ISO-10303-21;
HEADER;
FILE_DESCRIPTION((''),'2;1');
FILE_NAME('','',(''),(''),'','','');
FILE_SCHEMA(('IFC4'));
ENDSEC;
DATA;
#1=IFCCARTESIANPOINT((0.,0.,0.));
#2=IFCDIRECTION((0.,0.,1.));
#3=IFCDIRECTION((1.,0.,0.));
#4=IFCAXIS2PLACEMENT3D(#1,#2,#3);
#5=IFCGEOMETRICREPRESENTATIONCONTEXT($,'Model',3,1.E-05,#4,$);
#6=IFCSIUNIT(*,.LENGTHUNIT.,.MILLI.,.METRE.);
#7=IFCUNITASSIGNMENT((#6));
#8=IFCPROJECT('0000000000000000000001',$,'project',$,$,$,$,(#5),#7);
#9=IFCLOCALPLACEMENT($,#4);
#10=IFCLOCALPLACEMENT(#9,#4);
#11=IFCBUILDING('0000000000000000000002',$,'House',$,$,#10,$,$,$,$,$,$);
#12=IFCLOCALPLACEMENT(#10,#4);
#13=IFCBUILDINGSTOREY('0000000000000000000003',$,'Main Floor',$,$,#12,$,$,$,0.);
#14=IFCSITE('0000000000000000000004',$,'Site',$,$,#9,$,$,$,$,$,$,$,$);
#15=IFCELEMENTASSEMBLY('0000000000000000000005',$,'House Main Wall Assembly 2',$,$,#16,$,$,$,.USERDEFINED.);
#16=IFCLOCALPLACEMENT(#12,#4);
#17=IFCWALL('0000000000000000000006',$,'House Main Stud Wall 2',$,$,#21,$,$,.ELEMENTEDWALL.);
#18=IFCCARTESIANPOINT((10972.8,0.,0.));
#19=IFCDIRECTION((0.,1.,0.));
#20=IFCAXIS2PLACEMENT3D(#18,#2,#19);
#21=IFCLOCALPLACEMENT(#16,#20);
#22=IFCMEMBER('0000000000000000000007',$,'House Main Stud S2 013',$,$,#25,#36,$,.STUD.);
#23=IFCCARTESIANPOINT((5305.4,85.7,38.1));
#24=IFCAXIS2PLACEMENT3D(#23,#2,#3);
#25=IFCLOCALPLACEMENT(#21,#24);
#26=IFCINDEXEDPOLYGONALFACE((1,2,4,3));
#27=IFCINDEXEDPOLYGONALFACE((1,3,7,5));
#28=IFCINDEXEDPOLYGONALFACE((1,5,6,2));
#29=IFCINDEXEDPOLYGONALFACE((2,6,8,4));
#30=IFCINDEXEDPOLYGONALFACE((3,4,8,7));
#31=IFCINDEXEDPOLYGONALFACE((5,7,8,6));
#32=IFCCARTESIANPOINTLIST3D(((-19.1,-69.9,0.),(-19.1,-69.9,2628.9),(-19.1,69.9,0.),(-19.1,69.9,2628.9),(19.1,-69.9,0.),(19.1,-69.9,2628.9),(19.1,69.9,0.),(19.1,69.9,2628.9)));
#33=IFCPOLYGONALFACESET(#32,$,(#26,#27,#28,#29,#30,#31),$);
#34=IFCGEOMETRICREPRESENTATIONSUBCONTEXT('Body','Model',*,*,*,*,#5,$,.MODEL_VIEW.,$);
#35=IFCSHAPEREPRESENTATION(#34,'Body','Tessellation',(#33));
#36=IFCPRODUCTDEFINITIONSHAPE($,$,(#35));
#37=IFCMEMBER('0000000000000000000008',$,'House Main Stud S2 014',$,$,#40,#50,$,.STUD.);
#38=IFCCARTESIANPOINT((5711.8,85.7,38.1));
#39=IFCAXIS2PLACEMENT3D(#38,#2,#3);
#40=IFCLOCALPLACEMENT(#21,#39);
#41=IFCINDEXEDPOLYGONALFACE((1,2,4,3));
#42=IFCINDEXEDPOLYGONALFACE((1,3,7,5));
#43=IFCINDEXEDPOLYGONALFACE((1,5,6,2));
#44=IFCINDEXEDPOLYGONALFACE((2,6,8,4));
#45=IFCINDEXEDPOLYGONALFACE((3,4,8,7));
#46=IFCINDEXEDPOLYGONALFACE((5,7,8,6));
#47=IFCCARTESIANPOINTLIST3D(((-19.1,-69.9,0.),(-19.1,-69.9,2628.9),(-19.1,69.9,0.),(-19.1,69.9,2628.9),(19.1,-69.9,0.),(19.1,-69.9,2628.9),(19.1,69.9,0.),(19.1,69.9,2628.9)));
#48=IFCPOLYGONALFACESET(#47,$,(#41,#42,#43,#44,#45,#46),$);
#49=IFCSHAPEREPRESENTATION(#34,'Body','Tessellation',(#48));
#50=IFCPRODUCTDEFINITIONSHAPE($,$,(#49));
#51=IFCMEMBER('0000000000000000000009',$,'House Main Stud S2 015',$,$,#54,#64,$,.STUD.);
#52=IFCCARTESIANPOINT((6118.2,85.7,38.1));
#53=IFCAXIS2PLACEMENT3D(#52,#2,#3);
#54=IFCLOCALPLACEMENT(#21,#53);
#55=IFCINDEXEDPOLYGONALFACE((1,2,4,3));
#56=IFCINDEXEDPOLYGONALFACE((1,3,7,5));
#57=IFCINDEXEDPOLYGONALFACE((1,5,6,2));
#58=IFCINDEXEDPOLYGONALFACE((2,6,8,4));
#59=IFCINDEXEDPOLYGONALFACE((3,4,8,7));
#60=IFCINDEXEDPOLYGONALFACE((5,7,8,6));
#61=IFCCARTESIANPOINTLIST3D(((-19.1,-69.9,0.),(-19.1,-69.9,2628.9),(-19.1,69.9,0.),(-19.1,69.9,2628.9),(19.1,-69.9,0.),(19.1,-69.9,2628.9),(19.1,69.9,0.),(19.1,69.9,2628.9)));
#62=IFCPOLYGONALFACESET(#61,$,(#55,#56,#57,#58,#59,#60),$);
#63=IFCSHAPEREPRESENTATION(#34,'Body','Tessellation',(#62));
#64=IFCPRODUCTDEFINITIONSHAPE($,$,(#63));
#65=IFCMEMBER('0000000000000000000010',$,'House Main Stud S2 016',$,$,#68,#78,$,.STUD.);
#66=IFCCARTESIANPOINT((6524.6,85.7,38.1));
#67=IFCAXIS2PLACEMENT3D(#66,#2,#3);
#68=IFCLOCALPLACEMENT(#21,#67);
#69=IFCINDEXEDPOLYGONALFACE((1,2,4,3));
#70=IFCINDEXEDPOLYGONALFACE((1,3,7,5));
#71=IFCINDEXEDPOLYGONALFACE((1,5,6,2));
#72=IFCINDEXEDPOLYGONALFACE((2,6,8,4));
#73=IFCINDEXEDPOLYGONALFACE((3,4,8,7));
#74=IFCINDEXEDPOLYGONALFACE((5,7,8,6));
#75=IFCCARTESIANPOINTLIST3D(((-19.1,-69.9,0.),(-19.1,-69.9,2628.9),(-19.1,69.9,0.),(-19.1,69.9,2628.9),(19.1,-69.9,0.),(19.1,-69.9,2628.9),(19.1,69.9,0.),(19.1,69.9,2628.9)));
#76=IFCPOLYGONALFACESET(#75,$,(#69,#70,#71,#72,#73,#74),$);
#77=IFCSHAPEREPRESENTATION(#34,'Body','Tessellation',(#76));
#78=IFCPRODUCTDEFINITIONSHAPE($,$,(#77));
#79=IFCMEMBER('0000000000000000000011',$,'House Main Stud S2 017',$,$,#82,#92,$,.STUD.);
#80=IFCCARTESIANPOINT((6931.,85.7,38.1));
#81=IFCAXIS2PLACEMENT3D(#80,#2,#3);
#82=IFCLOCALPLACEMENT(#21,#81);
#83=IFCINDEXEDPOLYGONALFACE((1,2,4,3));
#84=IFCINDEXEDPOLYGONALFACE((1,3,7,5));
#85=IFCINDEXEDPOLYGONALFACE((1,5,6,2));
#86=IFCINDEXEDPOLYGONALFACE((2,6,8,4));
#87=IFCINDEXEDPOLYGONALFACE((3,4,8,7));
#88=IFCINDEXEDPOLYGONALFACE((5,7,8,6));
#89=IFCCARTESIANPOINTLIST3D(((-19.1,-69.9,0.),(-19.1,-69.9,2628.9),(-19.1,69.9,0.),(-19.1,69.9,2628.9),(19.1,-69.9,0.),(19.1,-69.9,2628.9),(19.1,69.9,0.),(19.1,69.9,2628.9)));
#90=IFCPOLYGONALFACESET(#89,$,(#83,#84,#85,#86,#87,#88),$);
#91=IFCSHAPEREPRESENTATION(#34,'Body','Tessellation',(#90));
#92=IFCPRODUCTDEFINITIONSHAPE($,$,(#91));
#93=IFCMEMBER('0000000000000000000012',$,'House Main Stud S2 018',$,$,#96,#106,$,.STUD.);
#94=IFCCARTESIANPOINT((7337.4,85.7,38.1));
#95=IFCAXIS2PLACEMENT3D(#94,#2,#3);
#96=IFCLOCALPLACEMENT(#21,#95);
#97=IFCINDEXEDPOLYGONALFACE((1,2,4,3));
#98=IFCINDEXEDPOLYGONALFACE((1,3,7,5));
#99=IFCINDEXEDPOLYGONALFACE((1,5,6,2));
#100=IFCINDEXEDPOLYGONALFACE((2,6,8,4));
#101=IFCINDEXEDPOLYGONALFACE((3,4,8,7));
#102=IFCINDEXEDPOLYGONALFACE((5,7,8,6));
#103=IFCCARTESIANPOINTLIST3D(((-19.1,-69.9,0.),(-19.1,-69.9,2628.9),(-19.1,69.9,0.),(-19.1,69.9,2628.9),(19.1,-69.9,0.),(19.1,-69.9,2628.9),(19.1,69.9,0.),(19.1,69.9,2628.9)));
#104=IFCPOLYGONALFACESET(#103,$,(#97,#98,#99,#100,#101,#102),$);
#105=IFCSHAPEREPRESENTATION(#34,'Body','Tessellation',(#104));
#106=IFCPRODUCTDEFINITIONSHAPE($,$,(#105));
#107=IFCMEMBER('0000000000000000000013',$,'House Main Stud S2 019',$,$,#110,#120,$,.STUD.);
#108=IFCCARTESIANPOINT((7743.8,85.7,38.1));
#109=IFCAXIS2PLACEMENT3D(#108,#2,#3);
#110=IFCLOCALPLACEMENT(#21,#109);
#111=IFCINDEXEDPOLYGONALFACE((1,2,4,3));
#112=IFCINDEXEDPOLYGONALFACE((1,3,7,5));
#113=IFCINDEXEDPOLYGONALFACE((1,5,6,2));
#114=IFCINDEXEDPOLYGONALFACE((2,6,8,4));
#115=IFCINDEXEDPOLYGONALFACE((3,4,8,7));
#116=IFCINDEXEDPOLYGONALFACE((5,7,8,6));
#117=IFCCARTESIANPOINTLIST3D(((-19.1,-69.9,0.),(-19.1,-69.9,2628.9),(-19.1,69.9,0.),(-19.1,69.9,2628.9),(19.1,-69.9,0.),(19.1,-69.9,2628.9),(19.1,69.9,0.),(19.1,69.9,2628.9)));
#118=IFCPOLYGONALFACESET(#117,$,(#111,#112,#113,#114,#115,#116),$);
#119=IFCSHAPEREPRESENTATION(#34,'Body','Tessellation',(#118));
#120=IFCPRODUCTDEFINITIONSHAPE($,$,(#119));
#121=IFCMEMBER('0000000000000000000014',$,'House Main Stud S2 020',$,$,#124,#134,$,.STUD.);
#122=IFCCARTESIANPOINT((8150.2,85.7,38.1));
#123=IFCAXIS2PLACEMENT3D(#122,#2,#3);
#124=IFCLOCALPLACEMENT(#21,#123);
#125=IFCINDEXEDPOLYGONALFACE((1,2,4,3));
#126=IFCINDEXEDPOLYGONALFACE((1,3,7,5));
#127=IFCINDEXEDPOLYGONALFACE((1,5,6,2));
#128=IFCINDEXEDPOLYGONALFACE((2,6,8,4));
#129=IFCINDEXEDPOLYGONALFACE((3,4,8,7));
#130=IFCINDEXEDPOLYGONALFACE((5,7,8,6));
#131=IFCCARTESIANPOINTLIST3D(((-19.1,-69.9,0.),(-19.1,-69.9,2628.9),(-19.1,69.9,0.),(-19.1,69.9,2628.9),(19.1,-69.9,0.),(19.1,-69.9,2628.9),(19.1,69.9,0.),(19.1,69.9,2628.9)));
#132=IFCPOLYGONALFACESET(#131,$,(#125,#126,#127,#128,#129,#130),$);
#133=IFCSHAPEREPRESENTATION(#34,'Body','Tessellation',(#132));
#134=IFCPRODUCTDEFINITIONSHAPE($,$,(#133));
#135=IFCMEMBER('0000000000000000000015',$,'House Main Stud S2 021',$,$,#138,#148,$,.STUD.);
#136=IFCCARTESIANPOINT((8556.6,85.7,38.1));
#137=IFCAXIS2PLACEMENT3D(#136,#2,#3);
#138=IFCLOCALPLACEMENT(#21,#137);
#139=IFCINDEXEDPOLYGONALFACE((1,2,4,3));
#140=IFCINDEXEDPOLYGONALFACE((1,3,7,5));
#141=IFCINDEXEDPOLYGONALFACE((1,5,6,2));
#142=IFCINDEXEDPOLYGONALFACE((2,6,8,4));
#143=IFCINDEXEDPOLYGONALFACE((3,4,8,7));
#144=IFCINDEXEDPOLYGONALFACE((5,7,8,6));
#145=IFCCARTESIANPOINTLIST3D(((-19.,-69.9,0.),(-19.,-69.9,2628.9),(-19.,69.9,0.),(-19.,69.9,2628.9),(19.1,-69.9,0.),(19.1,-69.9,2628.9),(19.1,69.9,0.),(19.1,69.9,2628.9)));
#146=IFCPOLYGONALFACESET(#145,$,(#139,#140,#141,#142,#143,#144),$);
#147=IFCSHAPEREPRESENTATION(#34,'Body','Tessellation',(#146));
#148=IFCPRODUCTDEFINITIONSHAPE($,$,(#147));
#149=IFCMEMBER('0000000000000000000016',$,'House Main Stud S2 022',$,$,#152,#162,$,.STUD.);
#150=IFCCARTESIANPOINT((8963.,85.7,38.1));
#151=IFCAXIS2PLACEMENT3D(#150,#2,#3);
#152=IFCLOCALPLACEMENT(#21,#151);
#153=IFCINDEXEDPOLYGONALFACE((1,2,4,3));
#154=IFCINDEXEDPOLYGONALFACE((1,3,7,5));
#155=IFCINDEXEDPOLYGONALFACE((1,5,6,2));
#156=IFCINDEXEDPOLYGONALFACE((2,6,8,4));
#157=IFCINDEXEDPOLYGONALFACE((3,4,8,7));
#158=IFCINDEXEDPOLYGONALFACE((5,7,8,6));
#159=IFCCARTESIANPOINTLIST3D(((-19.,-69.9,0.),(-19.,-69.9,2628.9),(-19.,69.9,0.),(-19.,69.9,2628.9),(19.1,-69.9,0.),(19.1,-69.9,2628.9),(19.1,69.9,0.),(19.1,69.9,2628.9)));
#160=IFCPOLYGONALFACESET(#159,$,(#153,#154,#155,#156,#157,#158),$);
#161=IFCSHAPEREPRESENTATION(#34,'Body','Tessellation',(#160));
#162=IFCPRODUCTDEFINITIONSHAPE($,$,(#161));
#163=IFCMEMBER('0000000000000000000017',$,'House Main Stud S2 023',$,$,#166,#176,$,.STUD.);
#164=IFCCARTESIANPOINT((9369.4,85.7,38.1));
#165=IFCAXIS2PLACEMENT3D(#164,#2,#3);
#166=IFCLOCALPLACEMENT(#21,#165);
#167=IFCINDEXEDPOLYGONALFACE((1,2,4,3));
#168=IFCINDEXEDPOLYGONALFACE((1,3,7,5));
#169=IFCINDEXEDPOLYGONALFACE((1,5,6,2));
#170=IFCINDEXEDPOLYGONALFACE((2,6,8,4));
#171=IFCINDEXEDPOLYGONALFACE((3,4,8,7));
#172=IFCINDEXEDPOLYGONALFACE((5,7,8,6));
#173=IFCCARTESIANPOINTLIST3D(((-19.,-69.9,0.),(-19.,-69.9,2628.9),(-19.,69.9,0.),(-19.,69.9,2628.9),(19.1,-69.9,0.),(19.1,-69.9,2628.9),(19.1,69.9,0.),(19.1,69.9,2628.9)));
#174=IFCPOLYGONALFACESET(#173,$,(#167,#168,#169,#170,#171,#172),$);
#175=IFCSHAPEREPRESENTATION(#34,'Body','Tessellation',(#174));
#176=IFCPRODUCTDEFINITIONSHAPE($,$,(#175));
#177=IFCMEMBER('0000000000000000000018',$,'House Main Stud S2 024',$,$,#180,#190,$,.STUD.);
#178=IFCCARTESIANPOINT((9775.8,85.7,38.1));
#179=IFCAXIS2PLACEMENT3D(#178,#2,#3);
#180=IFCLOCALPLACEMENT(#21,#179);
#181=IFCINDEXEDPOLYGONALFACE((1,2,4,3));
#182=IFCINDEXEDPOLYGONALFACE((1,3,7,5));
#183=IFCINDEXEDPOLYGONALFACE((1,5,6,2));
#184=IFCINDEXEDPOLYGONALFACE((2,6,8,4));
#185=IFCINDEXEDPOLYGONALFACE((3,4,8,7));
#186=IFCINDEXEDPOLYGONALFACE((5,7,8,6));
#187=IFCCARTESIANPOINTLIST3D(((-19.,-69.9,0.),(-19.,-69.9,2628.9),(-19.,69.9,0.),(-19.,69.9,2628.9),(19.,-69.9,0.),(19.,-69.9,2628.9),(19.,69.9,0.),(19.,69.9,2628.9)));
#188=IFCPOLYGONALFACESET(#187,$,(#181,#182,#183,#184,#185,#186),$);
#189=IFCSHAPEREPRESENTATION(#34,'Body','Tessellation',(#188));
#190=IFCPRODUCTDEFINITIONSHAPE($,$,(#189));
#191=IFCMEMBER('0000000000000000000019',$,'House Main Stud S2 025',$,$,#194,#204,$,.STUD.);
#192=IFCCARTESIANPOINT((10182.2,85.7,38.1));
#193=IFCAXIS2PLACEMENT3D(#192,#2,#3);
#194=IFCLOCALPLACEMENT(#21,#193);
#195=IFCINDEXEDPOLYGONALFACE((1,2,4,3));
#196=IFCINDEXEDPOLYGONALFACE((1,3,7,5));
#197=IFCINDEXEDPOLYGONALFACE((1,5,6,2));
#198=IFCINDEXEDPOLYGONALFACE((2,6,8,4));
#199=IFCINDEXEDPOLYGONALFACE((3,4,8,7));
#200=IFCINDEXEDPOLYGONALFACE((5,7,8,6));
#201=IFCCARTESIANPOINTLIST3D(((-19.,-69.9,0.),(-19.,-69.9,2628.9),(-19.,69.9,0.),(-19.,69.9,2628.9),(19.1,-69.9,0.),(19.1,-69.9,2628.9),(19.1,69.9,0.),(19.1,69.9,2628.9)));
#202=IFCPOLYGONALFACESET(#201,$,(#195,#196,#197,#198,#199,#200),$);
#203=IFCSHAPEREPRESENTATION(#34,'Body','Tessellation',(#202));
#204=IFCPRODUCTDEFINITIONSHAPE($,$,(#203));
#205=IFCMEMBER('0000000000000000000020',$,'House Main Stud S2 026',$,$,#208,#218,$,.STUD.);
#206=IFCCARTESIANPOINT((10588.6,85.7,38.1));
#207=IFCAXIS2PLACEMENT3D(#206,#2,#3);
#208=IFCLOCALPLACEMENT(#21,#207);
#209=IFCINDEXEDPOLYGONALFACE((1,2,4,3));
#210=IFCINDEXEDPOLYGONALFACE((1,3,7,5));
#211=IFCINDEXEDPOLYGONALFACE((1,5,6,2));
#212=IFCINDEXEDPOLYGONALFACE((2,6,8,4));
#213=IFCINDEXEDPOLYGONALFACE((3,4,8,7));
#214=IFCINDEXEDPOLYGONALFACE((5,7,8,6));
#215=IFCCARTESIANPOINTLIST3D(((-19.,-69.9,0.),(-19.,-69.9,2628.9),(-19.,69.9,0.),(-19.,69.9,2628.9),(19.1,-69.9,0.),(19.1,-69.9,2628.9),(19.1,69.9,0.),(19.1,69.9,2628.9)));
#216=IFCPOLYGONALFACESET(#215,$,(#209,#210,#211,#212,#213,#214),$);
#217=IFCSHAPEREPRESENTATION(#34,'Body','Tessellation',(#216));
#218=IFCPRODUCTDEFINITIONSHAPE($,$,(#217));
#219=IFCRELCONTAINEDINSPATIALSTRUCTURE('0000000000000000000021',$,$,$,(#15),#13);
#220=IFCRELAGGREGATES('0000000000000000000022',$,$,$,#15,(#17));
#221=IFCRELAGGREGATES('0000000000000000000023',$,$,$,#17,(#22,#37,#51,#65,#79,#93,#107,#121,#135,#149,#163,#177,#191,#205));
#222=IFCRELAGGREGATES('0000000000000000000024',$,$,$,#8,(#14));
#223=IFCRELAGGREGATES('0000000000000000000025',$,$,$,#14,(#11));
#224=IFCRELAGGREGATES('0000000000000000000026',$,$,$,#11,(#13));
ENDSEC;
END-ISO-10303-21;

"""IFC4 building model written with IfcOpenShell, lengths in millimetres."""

from ifc_helpers import new_model, si_unit, frame, origin_with_axes, origin_2d, place, context, subcontext, project, spatial, rectangle, extrude, element, aggregate, save


model = new_model("IFC4")

# Units and contexts
model_context = context("Model", 3, precision=1e-05, world=origin_with_axes())
body_context = subcontext(model_context, "Body", "Model", "MODEL_VIEW")
ifc_project = project(units=[si_unit("LENGTHUNIT", "METRE", prefix="MILLI")], contexts=[model_context])

# Site, building, storey
site_placement = place(None, origin_with_axes())
site = spatial("IfcSite", under=ifc_project, at=site_placement, Name="Site")
building_placement = place(site_placement, origin_with_axes())
building = spatial("IfcBuilding", under=site, at=building_placement, Name="House")
storey_placement = place(building_placement, origin_with_axes())
storey = spatial("IfcBuildingStorey", under=building, at=storey_placement, Name="Main Floor", Elevation=0.0)

# Element assembly, wall, members
assembly_1_placement = place(storey_placement, origin_with_axes())
assembly_1 = element("IfcElementAssembly", 1, at=assembly_1_placement, inside=storey, Name="House Main Wall Assembly 2", PredefinedType="USERDEFINED")
wall_1_placement = place(assembly_1_placement, frame((10972.8, 0.0, 0.0), z_axis=(0.0, 0.0, 1.0), x_axis=(0.0, 1.0, 0.0)))
wall_1 = element("IfcWall", 2, at=wall_1_placement, Name="House Main Stud Wall 2", PredefinedType="ELEMENTEDWALL")
aggregate(assembly_1, [wall_1])
member_1_placement = place(wall_1_placement, frame((5305.4, 85.7, 38.1), z_axis=(0.0, 0.0, 1.0), x_axis=(1.0, 0.0, 0.0)))
member_1 = element("IfcMember", 3, at=member_1_placement, Name="House Main Stud S2 013", PredefinedType="STUD", context=body_context, shape_type="SweptSolid", body=[
    extrude(rectangle(XDim=38.1, YDim=139.7, at=origin_2d()), origin_with_axes(), (0.0, 0.0, 1.0), 2628.9),
])
member_2_placement = place(wall_1_placement, frame((5711.8, 85.7, 38.1), z_axis=(0.0, 0.0, 1.0), x_axis=(1.0, 0.0, 0.0)))
member_2 = element("IfcMember", 4, at=member_2_placement, Name="House Main Stud S2 014", PredefinedType="STUD", context=body_context, shape_type="SweptSolid", body=[
    extrude(rectangle(XDim=38.1, YDim=139.7, at=origin_2d()), origin_with_axes(), (0.0, 0.0, 1.0), 2628.9),
])
member_3_placement = place(wall_1_placement, frame((6118.2, 85.7, 38.1), z_axis=(0.0, 0.0, 1.0), x_axis=(1.0, 0.0, 0.0)))
member_3 = element("IfcMember", 5, at=member_3_placement, Name="House Main Stud S2 015", PredefinedType="STUD", context=body_context, shape_type="SweptSolid", body=[
    extrude(rectangle(XDim=38.1, YDim=139.7, at=origin_2d()), origin_with_axes(), (0.0, 0.0, 1.0), 2628.9),
])
member_4_placement = place(wall_1_placement, frame((6524.6, 85.7, 38.1), z_axis=(0.0, 0.0, 1.0), x_axis=(1.0, 0.0, 0.0)))
member_4 = element("IfcMember", 6, at=member_4_placement, Name="House Main Stud S2 016", PredefinedType="STUD", context=body_context, shape_type="SweptSolid", body=[
    extrude(rectangle(XDim=38.1, YDim=139.7, at=origin_2d()), origin_with_axes(), (0.0, 0.0, 1.0), 2628.9),
])
member_5_placement = place(wall_1_placement, frame((6931.0, 85.7, 38.1), z_axis=(0.0, 0.0, 1.0), x_axis=(1.0, 0.0, 0.0)))
member_5 = element("IfcMember", 7, at=member_5_placement, Name="House Main Stud S2 017", PredefinedType="STUD", context=body_context, shape_type="SweptSolid", body=[
    extrude(rectangle(XDim=38.1, YDim=139.7, at=origin_2d()), origin_with_axes(), (0.0, 0.0, 1.0), 2628.9),
])
member_6_placement = place(wall_1_placement, frame((7337.4, 85.7, 38.1), z_axis=(0.0, 0.0, 1.0), x_axis=(1.0, 0.0, 0.0)))
member_6 = element("IfcMember", 8, at=member_6_placement, Name="House Main Stud S2 018", PredefinedType="STUD", context=body_context, shape_type="SweptSolid", body=[
    extrude(rectangle(XDim=38.1, YDim=139.7, at=origin_2d()), origin_with_axes(), (0.0, 0.0, 1.0), 2628.9),
])
member_7_placement = place(wall_1_placement, frame((7743.8, 85.7, 38.1), z_axis=(0.0, 0.0, 1.0), x_axis=(1.0, 0.0, 0.0)))
member_7 = element("IfcMember", 9, at=member_7_placement, Name="House Main Stud S2 019", PredefinedType="STUD", context=body_context, shape_type="SweptSolid", body=[
    extrude(rectangle(XDim=38.1, YDim=139.7, at=origin_2d()), origin_with_axes(), (0.0, 0.0, 1.0), 2628.9),
])
member_8_placement = place(wall_1_placement, frame((8150.2, 85.7, 38.1), z_axis=(0.0, 0.0, 1.0), x_axis=(1.0, 0.0, 0.0)))
member_8 = element("IfcMember", 10, at=member_8_placement, Name="House Main Stud S2 020", PredefinedType="STUD", context=body_context, shape_type="SweptSolid", body=[
    extrude(rectangle(XDim=38.1, YDim=139.7, at=origin_2d()), origin_with_axes(), (0.0, 0.0, 1.0), 2628.9),
])
member_9_placement = place(wall_1_placement, frame((8556.6, 85.7, 38.1), z_axis=(0.0, 0.0, 1.0), x_axis=(1.0, 0.0, 0.0)))
member_9 = element("IfcMember", 11, at=member_9_placement, Name="House Main Stud S2 021", PredefinedType="STUD", context=body_context, shape_type="SweptSolid", body=[
    extrude(rectangle(XDim=38.1, YDim=139.7, at=origin_2d()), origin_with_axes(), (0.0, 0.0, 1.0), 2628.9),
])
member_10_placement = place(wall_1_placement, frame((8963.0, 85.7, 38.1), z_axis=(0.0, 0.0, 1.0), x_axis=(1.0, 0.0, 0.0)))
member_10 = element("IfcMember", 12, at=member_10_placement, Name="House Main Stud S2 022", PredefinedType="STUD", context=body_context, shape_type="SweptSolid", body=[
    extrude(rectangle(XDim=38.1, YDim=139.7, at=origin_2d()), origin_with_axes(), (0.0, 0.0, 1.0), 2628.9),
])
member_11_placement = place(wall_1_placement, frame((9369.4, 85.7, 38.1), z_axis=(0.0, 0.0, 1.0), x_axis=(1.0, 0.0, 0.0)))
member_11 = element("IfcMember", 13, at=member_11_placement, Name="House Main Stud S2 023", PredefinedType="STUD", context=body_context, shape_type="SweptSolid", body=[
    extrude(rectangle(XDim=38.1, YDim=139.7, at=origin_2d()), origin_with_axes(), (0.0, 0.0, 1.0), 2628.9),
])
member_12_placement = place(wall_1_placement, frame((9775.8, 85.7, 38.1), z_axis=(0.0, 0.0, 1.0), x_axis=(1.0, 0.0, 0.0)))
member_12 = element("IfcMember", 14, at=member_12_placement, Name="House Main Stud S2 024", PredefinedType="STUD", context=body_context, shape_type="SweptSolid", body=[
    extrude(rectangle(XDim=38.1, YDim=139.7, at=origin_2d()), origin_with_axes(), (0.0, 0.0, 1.0), 2628.9),
])
member_13_placement = place(wall_1_placement, frame((10182.2, 85.7, 38.1), z_axis=(0.0, 0.0, 1.0), x_axis=(1.0, 0.0, 0.0)))
member_13 = element("IfcMember", 15, at=member_13_placement, Name="House Main Stud S2 025", PredefinedType="STUD", context=body_context, shape_type="SweptSolid", body=[
    extrude(rectangle(XDim=38.1, YDim=139.7, at=origin_2d()), origin_with_axes(), (0.0, 0.0, 1.0), 2628.9),
])
member_14_placement = place(wall_1_placement, frame((10588.6, 85.7, 38.1), z_axis=(0.0, 0.0, 1.0), x_axis=(1.0, 0.0, 0.0)))
member_14 = element("IfcMember", 16, at=member_14_placement, Name="House Main Stud S2 026", PredefinedType="STUD", context=body_context, shape_type="SweptSolid", body=[
    extrude(rectangle(XDim=38.1, YDim=139.7, at=origin_2d()), origin_with_axes(), (0.0, 0.0, 1.0), 2628.9),
])
aggregate(wall_1, [member_1, member_2, member_3, member_4, member_5, member_6, member_7, member_8, member_9, member_10, member_11, member_12, member_13, member_14])

save(model, "model.ifc")
